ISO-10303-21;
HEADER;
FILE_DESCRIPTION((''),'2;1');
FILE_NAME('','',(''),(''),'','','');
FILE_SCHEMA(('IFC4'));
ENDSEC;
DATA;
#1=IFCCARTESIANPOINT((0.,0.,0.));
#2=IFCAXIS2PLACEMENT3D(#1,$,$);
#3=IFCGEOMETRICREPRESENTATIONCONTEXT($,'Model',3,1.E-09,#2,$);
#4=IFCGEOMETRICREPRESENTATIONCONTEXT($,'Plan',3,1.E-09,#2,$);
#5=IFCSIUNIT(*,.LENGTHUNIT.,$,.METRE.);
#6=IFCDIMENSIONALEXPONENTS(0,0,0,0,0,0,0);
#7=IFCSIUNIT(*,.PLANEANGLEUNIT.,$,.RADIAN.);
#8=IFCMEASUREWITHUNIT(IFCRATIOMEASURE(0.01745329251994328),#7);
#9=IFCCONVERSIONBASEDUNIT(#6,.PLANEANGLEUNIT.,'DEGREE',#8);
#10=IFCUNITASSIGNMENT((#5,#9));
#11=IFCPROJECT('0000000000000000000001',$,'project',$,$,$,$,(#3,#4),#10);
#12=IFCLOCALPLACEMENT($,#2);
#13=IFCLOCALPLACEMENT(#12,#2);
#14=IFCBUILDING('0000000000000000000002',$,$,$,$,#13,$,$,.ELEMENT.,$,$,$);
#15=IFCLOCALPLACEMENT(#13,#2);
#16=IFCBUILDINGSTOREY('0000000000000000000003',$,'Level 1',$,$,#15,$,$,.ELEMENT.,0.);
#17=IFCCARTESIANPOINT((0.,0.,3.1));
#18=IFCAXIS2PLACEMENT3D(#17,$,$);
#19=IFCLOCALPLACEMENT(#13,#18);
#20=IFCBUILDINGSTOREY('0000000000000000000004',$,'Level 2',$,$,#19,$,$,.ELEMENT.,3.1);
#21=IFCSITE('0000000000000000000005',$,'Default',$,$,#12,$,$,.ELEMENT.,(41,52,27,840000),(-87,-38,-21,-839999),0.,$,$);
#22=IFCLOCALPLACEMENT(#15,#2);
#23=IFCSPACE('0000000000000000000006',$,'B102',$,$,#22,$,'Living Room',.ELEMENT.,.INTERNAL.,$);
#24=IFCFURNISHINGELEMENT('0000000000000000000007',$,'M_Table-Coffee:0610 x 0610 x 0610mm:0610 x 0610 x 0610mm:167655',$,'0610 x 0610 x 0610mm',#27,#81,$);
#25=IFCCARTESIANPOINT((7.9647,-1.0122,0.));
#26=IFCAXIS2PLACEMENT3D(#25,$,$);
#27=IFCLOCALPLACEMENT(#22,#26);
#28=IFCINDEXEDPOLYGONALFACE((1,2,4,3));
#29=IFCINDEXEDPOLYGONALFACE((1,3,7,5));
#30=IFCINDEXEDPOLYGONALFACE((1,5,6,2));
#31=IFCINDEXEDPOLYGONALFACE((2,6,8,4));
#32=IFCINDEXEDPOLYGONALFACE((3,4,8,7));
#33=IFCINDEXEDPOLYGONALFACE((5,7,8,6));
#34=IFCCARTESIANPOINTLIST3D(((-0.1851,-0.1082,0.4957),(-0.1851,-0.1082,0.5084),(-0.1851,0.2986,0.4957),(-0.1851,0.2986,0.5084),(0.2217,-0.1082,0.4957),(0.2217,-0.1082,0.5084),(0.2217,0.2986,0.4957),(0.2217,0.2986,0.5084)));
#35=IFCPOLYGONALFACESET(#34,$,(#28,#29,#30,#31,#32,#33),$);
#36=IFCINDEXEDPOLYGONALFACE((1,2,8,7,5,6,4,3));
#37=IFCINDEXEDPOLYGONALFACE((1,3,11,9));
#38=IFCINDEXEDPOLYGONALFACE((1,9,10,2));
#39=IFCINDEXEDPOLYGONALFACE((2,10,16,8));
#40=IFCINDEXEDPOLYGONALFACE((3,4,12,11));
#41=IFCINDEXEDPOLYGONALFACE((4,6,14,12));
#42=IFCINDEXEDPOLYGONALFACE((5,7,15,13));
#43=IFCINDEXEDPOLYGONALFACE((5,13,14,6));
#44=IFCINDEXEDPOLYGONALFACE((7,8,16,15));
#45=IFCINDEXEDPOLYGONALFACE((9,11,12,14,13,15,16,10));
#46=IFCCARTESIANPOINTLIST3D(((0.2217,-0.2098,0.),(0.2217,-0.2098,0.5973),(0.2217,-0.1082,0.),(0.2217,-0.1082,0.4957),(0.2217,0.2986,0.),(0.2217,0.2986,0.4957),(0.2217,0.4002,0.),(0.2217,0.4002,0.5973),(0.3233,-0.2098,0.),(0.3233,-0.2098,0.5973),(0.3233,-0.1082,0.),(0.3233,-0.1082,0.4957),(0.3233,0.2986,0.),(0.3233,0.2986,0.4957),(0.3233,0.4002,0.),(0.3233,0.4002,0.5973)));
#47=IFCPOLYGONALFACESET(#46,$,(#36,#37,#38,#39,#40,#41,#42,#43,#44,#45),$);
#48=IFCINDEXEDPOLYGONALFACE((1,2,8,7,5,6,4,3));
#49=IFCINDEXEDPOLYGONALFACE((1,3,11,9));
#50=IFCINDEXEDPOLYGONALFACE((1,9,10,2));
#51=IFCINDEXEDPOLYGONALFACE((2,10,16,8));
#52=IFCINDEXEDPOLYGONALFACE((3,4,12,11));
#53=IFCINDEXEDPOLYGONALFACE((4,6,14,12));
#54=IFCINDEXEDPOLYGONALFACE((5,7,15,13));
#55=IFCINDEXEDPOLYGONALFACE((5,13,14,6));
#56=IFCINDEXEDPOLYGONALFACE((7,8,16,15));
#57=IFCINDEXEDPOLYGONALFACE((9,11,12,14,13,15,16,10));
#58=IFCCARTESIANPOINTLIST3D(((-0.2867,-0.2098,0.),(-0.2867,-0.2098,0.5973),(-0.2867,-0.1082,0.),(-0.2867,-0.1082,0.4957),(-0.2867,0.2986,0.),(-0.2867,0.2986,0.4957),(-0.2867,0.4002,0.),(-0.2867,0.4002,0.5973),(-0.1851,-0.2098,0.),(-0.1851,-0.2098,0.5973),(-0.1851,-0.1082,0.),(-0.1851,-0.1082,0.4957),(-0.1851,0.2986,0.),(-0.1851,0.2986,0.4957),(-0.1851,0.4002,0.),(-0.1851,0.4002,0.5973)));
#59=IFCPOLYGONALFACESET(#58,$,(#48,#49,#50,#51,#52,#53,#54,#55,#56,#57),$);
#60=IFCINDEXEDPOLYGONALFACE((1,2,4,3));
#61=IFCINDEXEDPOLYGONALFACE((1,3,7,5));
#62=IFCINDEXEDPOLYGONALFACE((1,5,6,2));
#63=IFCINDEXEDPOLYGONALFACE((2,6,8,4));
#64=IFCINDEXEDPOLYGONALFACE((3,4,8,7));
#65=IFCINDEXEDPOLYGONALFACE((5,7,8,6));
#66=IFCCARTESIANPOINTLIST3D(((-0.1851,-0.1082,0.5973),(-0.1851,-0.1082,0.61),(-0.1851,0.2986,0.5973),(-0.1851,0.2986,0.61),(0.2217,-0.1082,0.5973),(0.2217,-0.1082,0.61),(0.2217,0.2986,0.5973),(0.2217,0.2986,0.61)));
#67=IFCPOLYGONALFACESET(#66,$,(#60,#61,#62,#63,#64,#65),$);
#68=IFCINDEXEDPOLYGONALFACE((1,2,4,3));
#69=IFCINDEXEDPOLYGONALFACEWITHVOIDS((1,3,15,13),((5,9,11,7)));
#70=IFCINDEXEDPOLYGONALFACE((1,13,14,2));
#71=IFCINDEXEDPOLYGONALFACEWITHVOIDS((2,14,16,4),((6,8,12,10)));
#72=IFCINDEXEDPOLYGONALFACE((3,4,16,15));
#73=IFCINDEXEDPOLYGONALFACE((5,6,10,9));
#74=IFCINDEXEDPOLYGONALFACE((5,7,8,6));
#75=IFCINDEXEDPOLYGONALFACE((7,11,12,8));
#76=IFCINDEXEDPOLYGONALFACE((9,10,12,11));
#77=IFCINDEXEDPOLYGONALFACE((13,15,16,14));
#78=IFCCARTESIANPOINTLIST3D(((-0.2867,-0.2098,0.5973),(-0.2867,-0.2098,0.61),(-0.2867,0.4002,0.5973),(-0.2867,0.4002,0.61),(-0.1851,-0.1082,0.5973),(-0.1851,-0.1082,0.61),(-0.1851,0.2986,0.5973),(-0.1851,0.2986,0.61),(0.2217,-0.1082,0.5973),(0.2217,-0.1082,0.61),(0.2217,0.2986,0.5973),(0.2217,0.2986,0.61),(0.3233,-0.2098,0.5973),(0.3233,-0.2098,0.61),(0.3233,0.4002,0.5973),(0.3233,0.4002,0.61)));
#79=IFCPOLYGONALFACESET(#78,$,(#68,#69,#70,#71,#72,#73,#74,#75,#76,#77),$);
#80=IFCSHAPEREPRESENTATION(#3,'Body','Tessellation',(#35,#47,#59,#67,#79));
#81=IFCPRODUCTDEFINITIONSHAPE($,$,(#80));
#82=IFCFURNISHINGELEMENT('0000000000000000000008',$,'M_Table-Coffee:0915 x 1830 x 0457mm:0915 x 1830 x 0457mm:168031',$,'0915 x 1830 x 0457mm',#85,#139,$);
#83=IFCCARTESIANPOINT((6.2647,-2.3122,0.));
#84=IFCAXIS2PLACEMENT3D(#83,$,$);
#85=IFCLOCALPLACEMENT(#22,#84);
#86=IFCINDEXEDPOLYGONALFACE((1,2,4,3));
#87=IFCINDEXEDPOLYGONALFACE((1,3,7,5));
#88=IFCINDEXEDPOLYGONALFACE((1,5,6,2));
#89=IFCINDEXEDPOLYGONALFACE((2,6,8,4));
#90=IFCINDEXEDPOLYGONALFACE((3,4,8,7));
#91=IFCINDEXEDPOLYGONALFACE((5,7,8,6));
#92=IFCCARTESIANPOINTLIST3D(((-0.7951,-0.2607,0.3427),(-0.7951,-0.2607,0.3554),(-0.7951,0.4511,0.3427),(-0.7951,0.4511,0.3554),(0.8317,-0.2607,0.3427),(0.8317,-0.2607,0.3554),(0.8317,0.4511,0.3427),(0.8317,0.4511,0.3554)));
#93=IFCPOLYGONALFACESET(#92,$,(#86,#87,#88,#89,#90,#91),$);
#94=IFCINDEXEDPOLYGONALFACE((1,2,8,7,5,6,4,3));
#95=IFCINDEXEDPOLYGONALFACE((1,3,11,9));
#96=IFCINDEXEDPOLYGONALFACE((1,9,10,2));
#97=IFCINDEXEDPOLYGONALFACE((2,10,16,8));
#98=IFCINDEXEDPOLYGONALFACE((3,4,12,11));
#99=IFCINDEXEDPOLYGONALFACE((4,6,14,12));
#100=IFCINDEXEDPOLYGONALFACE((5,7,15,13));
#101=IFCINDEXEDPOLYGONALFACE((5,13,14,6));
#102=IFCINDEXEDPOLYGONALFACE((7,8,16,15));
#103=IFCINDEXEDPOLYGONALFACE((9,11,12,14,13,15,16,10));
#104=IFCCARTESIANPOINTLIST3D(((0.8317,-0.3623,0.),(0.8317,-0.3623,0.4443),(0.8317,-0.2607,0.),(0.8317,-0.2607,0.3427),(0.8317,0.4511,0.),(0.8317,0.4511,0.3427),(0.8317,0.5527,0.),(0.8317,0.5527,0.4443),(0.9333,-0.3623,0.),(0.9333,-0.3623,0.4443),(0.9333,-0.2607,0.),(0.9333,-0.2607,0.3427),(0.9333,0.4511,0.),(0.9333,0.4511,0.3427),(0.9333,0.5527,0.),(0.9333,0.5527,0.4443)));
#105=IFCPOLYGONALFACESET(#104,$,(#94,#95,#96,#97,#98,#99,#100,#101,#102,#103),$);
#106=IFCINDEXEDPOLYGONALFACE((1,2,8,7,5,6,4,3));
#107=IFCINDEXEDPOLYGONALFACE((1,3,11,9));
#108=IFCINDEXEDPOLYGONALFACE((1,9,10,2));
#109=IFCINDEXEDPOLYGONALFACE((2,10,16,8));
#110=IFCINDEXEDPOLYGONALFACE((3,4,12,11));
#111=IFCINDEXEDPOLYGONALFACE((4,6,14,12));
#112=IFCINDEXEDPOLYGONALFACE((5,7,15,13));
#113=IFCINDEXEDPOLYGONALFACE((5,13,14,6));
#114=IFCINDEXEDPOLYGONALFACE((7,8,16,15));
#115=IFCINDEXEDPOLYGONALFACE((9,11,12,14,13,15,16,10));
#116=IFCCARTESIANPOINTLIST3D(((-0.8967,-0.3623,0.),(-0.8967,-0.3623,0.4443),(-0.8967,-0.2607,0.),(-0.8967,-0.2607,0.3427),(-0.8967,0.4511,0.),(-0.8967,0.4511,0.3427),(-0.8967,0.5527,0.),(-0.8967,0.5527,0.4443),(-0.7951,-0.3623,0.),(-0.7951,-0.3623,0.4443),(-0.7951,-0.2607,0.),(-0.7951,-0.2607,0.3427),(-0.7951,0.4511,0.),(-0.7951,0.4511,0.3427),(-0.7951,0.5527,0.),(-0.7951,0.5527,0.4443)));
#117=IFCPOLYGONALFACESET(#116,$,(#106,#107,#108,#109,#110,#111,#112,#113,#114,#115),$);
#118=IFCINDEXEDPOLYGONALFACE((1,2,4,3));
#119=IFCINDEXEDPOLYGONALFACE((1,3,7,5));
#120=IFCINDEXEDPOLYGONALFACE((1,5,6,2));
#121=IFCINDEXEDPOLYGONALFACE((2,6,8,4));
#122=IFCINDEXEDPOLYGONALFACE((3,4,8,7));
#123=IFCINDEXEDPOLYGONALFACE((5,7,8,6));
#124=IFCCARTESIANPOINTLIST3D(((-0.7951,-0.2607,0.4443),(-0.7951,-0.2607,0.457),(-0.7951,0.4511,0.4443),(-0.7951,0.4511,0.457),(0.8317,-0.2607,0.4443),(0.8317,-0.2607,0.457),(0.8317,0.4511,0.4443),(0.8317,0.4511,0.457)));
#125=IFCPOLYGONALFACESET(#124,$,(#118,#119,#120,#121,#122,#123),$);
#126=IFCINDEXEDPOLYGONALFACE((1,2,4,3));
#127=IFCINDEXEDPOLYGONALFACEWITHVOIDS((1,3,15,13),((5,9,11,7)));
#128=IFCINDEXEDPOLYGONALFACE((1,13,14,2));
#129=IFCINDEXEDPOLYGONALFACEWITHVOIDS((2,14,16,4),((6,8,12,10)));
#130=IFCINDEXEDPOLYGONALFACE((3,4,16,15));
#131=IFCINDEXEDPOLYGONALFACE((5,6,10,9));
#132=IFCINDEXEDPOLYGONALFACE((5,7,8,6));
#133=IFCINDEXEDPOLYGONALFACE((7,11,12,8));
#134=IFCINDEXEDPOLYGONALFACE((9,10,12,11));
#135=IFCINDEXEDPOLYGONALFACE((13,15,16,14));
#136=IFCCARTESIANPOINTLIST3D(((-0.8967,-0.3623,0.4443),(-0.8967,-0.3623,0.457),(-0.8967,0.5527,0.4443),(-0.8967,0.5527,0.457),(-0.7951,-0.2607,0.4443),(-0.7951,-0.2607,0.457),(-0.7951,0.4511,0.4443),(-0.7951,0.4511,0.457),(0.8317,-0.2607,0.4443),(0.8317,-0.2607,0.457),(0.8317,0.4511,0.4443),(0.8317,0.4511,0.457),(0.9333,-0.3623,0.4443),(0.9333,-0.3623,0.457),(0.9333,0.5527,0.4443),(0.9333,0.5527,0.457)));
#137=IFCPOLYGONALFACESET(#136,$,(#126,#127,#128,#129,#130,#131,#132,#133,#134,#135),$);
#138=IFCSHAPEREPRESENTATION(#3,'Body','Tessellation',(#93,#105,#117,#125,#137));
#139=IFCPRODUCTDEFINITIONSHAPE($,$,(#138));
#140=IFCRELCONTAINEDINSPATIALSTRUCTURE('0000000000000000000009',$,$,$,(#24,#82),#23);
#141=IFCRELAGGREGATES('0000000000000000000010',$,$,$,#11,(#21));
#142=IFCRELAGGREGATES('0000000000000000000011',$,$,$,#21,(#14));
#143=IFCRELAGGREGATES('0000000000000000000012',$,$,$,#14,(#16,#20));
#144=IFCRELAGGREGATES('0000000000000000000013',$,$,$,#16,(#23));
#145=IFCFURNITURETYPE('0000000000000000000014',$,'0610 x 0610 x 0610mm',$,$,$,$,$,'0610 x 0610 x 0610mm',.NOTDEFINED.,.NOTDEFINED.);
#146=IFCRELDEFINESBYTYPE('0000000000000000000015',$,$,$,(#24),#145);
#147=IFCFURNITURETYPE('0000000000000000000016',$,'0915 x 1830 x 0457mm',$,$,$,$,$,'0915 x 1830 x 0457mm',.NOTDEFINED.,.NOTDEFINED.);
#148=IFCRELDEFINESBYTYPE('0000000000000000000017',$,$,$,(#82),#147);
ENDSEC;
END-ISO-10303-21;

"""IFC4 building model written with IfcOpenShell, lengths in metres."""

from ifc_helpers import new_model, entity, si_unit, converted_unit, frame, origin, origin_2d_with_axis, place, context, project, spatial, polyline, rectangle, outline, extrude, source, transform, mapped, type_object, type_shapes, element, save


model = new_model("IFC4")

# Units and contexts
model_context = context("Model", 3, precision=1e-09, world=origin())
plan_context = context("Plan", 3, precision=1e-09, world=origin())
ifc_project = project(units=[si_unit("LENGTHUNIT", "METRE"), converted_unit("PLANEANGLEUNIT", "DEGREE", entity("IfcRatioMeasure", 0.01745329251994328), si_unit("PLANEANGLEUNIT", "RADIAN"), dimensions=[0, 0, 0, 0, 0, 0, 0])], contexts=[model_context, plan_context])

# Site, building, storey
site_placement = place(None, origin())
site = spatial("IfcSite", under=ifc_project, at=site_placement, Name="Default", CompositionType="ELEMENT", RefLatitude=(41, 52, 27, 840000), RefLongitude=(-87, -38, -21, -839999), RefElevation=0.0)
building_placement = place(site_placement, origin())
building = spatial("IfcBuilding", under=site, at=building_placement, CompositionType="ELEMENT")
storey_1_placement = place(building_placement, origin())
storey_1 = spatial("IfcBuildingStorey", under=building, at=storey_1_placement, Name="Level 1", CompositionType="ELEMENT", Elevation=0.0)

# Shared definitions
storey_2_placement = place(building_placement, frame((0.0, 0.0, 3.1)))
storey_2 = spatial("IfcBuildingStorey", under=building, at=storey_2_placement, Name="Level 2", CompositionType="ELEMENT", Elevation=3.1)

# Shared definitions
space_1_placement = place(storey_1_placement, origin())
space_1 = spatial("IfcSpace", under=storey_1, at=space_1_placement, Name="B102", LongName="Living Room", CompositionType="ELEMENT", PredefinedType="INTERNAL")

# Furnishing elements
furniture_type_1 = type_object("IfcFurnitureType", Name="0610 x 0610 x 0610mm", ElementType="0610 x 0610 x 0610mm", AssemblyPlace="NOTDEFINED")
shared_shape_1 = source(origin(), model_context, "Body", "SweptSolid", [
    extrude(rectangle(XDim=0.4068, YDim=0.4068, at=origin_2d_with_axis()), frame((0.0183, 0.0952, 0.4957), z_axis=(0.0, 0.0, 1.0), x_axis=(-1.0, 0.0, 0.0)), (0.0, 0.0, 1.0), 0.0127),
    extrude(outline(polyline([(-0.2732, -0.305), (0.324, -0.305), (0.324, 0.305), (-0.2732, 0.305), (-0.2732, 0.2034), (0.2225, 0.2034), (0.2225, -0.2034), (-0.2732, -0.2034), (-0.2732, -0.305)])), frame((0.2217, 0.0952, 0.2732), z_axis=(1.0, 0.0, 0.0), x_axis=(0.0, 0.0, 1.0)), (0.0, 0.0, 1.0), 0.1016),
    extrude(outline(polyline([(-0.305, -0.3241), (0.305, -0.3241), (0.305, 0.2733), (0.2034, 0.2733), (0.2034, -0.2224), (-0.2034, -0.2224), (-0.2034, 0.2733), (-0.305, 0.2733), (-0.305, -0.3241)])), frame((-0.2867, 0.0952, 0.2733), z_axis=(1.0, 0.0, 0.0), x_axis=(0.0, -1.0, 0.0)), (0.0, 0.0, 1.0), 0.1016),
    extrude(rectangle(XDim=0.4068, YDim=0.4068, at=origin_2d_with_axis()), frame((0.0183, 0.0952, 0.5973), z_axis=(0.0, 0.0, 1.0), x_axis=(-1.0, 0.0, 0.0)), (0.0, 0.0, 1.0), 0.0127),
    extrude(outline(polyline([(-0.305, -0.305), (0.305, -0.305), (0.305, 0.305), (-0.305, 0.305), (-0.305, -0.305)]), holes=[polyline([(-0.2034, -0.2034), (-0.2034, 0.2034), (0.2034, 0.2034), (0.2034, -0.2034), (-0.2034, -0.2034)])]), frame((0.0183, 0.0952, 0.5973), z_axis=(0.0, 0.0, 1.0), x_axis=(-1.0, 0.0, 0.0)), (0.0, 0.0, 1.0), 0.0127),
])
type_shapes(furniture_type_1, [shared_shape_1])
for number, where, name in (
    (1, (7.9647, -1.0122, 0.0), "M_Table-Coffee:0610 x 0610 x 0610mm:0610 x 0610 x 0610mm:167655"),
):
    element("IfcFurnishingElement", number, at=place(space_1_placement, frame(where)), inside=space_1, type_object=furniture_type_1, Name=name, ObjectType="0610 x 0610 x 0610mm", context=model_context, shape_type="MappedRepresentation", body=[
        mapped(shared_shape_1, transform((0.0, 0.0, 0.0), scale=1.0)),
    ])
furniture_type_2 = type_object("IfcFurnitureType", Name="0915 x 1830 x 0457mm", ElementType="0915 x 1830 x 0457mm", AssemblyPlace="NOTDEFINED")
shared_shape_2 = source(origin(), model_context, "Body", "SweptSolid", [
    extrude(rectangle(XDim=1.6268, YDim=0.7118, at=origin_2d_with_axis()), frame((0.0183, 0.0952, 0.3427), z_axis=(0.0, 0.0, 1.0), x_axis=(-1.0, 0.0, 0.0)), (0.0, 0.0, 1.0), 0.0127),
    extrude(outline(polyline([(-0.1967, -0.4575), (0.2475, -0.4575), (0.2475, 0.4575), (-0.1967, 0.4575), (-0.1967, 0.3559), (0.146, 0.3559), (0.146, -0.3559), (-0.1967, -0.3559), (-0.1967, -0.4575)])), frame((0.8317, 0.0952, 0.1967), z_axis=(1.0, 0.0, 0.0), x_axis=(0.0, 0.0, 1.0)), (0.0, 0.0, 1.0), 0.1016),
    extrude(outline(polyline([(-0.4575, -0.2476), (0.4575, -0.2476), (0.4575, 0.1968), (0.3559, 0.1968), (0.3559, -0.1459), (-0.3559, -0.1459), (-0.3559, 0.1968), (-0.4575, 0.1968), (-0.4575, -0.2476)])), frame((-0.8967, 0.0952, 0.1968), z_axis=(1.0, 0.0, 0.0), x_axis=(0.0, -1.0, 0.0)), (0.0, 0.0, 1.0), 0.1016),
    extrude(rectangle(XDim=1.6268, YDim=0.7118, at=origin_2d_with_axis()), frame((0.0183, 0.0952, 0.4443), z_axis=(0.0, 0.0, 1.0), x_axis=(-1.0, 0.0, 0.0)), (0.0, 0.0, 1.0), 0.0127),
    extrude(outline(polyline([(-0.915, -0.4575), (0.915, -0.4575), (0.915, 0.4575), (-0.915, 0.4575), (-0.915, -0.4575)]), holes=[polyline([(-0.8134, -0.3559), (-0.8134, 0.3559), (0.8134, 0.3559), (0.8134, -0.3559), (-0.8134, -0.3559)])]), frame((0.0183, 0.0952, 0.4443), z_axis=(0.0, 0.0, 1.0), x_axis=(-1.0, 0.0, 0.0)), (0.0, 0.0, 1.0), 0.0127),
])
type_shapes(furniture_type_2, [shared_shape_2])
furnishing_1_placement = place(space_1_placement, frame((6.2647, -2.3122, 0.0)))
element("IfcFurnishingElement", 2, at=furnishing_1_placement, inside=space_1, type_object=furniture_type_2, Name="M_Table-Coffee:0915 x 1830 x 0457mm:0915 x 1830 x 0457mm:168031", ObjectType="0915 x 1830 x 0457mm", context=model_context, shape_type="MappedRepresentation", body=[
    mapped(shared_shape_2, transform((0.0, 0.0, 0.0), scale=1.0)),
])

save(model, "model.ifc")
